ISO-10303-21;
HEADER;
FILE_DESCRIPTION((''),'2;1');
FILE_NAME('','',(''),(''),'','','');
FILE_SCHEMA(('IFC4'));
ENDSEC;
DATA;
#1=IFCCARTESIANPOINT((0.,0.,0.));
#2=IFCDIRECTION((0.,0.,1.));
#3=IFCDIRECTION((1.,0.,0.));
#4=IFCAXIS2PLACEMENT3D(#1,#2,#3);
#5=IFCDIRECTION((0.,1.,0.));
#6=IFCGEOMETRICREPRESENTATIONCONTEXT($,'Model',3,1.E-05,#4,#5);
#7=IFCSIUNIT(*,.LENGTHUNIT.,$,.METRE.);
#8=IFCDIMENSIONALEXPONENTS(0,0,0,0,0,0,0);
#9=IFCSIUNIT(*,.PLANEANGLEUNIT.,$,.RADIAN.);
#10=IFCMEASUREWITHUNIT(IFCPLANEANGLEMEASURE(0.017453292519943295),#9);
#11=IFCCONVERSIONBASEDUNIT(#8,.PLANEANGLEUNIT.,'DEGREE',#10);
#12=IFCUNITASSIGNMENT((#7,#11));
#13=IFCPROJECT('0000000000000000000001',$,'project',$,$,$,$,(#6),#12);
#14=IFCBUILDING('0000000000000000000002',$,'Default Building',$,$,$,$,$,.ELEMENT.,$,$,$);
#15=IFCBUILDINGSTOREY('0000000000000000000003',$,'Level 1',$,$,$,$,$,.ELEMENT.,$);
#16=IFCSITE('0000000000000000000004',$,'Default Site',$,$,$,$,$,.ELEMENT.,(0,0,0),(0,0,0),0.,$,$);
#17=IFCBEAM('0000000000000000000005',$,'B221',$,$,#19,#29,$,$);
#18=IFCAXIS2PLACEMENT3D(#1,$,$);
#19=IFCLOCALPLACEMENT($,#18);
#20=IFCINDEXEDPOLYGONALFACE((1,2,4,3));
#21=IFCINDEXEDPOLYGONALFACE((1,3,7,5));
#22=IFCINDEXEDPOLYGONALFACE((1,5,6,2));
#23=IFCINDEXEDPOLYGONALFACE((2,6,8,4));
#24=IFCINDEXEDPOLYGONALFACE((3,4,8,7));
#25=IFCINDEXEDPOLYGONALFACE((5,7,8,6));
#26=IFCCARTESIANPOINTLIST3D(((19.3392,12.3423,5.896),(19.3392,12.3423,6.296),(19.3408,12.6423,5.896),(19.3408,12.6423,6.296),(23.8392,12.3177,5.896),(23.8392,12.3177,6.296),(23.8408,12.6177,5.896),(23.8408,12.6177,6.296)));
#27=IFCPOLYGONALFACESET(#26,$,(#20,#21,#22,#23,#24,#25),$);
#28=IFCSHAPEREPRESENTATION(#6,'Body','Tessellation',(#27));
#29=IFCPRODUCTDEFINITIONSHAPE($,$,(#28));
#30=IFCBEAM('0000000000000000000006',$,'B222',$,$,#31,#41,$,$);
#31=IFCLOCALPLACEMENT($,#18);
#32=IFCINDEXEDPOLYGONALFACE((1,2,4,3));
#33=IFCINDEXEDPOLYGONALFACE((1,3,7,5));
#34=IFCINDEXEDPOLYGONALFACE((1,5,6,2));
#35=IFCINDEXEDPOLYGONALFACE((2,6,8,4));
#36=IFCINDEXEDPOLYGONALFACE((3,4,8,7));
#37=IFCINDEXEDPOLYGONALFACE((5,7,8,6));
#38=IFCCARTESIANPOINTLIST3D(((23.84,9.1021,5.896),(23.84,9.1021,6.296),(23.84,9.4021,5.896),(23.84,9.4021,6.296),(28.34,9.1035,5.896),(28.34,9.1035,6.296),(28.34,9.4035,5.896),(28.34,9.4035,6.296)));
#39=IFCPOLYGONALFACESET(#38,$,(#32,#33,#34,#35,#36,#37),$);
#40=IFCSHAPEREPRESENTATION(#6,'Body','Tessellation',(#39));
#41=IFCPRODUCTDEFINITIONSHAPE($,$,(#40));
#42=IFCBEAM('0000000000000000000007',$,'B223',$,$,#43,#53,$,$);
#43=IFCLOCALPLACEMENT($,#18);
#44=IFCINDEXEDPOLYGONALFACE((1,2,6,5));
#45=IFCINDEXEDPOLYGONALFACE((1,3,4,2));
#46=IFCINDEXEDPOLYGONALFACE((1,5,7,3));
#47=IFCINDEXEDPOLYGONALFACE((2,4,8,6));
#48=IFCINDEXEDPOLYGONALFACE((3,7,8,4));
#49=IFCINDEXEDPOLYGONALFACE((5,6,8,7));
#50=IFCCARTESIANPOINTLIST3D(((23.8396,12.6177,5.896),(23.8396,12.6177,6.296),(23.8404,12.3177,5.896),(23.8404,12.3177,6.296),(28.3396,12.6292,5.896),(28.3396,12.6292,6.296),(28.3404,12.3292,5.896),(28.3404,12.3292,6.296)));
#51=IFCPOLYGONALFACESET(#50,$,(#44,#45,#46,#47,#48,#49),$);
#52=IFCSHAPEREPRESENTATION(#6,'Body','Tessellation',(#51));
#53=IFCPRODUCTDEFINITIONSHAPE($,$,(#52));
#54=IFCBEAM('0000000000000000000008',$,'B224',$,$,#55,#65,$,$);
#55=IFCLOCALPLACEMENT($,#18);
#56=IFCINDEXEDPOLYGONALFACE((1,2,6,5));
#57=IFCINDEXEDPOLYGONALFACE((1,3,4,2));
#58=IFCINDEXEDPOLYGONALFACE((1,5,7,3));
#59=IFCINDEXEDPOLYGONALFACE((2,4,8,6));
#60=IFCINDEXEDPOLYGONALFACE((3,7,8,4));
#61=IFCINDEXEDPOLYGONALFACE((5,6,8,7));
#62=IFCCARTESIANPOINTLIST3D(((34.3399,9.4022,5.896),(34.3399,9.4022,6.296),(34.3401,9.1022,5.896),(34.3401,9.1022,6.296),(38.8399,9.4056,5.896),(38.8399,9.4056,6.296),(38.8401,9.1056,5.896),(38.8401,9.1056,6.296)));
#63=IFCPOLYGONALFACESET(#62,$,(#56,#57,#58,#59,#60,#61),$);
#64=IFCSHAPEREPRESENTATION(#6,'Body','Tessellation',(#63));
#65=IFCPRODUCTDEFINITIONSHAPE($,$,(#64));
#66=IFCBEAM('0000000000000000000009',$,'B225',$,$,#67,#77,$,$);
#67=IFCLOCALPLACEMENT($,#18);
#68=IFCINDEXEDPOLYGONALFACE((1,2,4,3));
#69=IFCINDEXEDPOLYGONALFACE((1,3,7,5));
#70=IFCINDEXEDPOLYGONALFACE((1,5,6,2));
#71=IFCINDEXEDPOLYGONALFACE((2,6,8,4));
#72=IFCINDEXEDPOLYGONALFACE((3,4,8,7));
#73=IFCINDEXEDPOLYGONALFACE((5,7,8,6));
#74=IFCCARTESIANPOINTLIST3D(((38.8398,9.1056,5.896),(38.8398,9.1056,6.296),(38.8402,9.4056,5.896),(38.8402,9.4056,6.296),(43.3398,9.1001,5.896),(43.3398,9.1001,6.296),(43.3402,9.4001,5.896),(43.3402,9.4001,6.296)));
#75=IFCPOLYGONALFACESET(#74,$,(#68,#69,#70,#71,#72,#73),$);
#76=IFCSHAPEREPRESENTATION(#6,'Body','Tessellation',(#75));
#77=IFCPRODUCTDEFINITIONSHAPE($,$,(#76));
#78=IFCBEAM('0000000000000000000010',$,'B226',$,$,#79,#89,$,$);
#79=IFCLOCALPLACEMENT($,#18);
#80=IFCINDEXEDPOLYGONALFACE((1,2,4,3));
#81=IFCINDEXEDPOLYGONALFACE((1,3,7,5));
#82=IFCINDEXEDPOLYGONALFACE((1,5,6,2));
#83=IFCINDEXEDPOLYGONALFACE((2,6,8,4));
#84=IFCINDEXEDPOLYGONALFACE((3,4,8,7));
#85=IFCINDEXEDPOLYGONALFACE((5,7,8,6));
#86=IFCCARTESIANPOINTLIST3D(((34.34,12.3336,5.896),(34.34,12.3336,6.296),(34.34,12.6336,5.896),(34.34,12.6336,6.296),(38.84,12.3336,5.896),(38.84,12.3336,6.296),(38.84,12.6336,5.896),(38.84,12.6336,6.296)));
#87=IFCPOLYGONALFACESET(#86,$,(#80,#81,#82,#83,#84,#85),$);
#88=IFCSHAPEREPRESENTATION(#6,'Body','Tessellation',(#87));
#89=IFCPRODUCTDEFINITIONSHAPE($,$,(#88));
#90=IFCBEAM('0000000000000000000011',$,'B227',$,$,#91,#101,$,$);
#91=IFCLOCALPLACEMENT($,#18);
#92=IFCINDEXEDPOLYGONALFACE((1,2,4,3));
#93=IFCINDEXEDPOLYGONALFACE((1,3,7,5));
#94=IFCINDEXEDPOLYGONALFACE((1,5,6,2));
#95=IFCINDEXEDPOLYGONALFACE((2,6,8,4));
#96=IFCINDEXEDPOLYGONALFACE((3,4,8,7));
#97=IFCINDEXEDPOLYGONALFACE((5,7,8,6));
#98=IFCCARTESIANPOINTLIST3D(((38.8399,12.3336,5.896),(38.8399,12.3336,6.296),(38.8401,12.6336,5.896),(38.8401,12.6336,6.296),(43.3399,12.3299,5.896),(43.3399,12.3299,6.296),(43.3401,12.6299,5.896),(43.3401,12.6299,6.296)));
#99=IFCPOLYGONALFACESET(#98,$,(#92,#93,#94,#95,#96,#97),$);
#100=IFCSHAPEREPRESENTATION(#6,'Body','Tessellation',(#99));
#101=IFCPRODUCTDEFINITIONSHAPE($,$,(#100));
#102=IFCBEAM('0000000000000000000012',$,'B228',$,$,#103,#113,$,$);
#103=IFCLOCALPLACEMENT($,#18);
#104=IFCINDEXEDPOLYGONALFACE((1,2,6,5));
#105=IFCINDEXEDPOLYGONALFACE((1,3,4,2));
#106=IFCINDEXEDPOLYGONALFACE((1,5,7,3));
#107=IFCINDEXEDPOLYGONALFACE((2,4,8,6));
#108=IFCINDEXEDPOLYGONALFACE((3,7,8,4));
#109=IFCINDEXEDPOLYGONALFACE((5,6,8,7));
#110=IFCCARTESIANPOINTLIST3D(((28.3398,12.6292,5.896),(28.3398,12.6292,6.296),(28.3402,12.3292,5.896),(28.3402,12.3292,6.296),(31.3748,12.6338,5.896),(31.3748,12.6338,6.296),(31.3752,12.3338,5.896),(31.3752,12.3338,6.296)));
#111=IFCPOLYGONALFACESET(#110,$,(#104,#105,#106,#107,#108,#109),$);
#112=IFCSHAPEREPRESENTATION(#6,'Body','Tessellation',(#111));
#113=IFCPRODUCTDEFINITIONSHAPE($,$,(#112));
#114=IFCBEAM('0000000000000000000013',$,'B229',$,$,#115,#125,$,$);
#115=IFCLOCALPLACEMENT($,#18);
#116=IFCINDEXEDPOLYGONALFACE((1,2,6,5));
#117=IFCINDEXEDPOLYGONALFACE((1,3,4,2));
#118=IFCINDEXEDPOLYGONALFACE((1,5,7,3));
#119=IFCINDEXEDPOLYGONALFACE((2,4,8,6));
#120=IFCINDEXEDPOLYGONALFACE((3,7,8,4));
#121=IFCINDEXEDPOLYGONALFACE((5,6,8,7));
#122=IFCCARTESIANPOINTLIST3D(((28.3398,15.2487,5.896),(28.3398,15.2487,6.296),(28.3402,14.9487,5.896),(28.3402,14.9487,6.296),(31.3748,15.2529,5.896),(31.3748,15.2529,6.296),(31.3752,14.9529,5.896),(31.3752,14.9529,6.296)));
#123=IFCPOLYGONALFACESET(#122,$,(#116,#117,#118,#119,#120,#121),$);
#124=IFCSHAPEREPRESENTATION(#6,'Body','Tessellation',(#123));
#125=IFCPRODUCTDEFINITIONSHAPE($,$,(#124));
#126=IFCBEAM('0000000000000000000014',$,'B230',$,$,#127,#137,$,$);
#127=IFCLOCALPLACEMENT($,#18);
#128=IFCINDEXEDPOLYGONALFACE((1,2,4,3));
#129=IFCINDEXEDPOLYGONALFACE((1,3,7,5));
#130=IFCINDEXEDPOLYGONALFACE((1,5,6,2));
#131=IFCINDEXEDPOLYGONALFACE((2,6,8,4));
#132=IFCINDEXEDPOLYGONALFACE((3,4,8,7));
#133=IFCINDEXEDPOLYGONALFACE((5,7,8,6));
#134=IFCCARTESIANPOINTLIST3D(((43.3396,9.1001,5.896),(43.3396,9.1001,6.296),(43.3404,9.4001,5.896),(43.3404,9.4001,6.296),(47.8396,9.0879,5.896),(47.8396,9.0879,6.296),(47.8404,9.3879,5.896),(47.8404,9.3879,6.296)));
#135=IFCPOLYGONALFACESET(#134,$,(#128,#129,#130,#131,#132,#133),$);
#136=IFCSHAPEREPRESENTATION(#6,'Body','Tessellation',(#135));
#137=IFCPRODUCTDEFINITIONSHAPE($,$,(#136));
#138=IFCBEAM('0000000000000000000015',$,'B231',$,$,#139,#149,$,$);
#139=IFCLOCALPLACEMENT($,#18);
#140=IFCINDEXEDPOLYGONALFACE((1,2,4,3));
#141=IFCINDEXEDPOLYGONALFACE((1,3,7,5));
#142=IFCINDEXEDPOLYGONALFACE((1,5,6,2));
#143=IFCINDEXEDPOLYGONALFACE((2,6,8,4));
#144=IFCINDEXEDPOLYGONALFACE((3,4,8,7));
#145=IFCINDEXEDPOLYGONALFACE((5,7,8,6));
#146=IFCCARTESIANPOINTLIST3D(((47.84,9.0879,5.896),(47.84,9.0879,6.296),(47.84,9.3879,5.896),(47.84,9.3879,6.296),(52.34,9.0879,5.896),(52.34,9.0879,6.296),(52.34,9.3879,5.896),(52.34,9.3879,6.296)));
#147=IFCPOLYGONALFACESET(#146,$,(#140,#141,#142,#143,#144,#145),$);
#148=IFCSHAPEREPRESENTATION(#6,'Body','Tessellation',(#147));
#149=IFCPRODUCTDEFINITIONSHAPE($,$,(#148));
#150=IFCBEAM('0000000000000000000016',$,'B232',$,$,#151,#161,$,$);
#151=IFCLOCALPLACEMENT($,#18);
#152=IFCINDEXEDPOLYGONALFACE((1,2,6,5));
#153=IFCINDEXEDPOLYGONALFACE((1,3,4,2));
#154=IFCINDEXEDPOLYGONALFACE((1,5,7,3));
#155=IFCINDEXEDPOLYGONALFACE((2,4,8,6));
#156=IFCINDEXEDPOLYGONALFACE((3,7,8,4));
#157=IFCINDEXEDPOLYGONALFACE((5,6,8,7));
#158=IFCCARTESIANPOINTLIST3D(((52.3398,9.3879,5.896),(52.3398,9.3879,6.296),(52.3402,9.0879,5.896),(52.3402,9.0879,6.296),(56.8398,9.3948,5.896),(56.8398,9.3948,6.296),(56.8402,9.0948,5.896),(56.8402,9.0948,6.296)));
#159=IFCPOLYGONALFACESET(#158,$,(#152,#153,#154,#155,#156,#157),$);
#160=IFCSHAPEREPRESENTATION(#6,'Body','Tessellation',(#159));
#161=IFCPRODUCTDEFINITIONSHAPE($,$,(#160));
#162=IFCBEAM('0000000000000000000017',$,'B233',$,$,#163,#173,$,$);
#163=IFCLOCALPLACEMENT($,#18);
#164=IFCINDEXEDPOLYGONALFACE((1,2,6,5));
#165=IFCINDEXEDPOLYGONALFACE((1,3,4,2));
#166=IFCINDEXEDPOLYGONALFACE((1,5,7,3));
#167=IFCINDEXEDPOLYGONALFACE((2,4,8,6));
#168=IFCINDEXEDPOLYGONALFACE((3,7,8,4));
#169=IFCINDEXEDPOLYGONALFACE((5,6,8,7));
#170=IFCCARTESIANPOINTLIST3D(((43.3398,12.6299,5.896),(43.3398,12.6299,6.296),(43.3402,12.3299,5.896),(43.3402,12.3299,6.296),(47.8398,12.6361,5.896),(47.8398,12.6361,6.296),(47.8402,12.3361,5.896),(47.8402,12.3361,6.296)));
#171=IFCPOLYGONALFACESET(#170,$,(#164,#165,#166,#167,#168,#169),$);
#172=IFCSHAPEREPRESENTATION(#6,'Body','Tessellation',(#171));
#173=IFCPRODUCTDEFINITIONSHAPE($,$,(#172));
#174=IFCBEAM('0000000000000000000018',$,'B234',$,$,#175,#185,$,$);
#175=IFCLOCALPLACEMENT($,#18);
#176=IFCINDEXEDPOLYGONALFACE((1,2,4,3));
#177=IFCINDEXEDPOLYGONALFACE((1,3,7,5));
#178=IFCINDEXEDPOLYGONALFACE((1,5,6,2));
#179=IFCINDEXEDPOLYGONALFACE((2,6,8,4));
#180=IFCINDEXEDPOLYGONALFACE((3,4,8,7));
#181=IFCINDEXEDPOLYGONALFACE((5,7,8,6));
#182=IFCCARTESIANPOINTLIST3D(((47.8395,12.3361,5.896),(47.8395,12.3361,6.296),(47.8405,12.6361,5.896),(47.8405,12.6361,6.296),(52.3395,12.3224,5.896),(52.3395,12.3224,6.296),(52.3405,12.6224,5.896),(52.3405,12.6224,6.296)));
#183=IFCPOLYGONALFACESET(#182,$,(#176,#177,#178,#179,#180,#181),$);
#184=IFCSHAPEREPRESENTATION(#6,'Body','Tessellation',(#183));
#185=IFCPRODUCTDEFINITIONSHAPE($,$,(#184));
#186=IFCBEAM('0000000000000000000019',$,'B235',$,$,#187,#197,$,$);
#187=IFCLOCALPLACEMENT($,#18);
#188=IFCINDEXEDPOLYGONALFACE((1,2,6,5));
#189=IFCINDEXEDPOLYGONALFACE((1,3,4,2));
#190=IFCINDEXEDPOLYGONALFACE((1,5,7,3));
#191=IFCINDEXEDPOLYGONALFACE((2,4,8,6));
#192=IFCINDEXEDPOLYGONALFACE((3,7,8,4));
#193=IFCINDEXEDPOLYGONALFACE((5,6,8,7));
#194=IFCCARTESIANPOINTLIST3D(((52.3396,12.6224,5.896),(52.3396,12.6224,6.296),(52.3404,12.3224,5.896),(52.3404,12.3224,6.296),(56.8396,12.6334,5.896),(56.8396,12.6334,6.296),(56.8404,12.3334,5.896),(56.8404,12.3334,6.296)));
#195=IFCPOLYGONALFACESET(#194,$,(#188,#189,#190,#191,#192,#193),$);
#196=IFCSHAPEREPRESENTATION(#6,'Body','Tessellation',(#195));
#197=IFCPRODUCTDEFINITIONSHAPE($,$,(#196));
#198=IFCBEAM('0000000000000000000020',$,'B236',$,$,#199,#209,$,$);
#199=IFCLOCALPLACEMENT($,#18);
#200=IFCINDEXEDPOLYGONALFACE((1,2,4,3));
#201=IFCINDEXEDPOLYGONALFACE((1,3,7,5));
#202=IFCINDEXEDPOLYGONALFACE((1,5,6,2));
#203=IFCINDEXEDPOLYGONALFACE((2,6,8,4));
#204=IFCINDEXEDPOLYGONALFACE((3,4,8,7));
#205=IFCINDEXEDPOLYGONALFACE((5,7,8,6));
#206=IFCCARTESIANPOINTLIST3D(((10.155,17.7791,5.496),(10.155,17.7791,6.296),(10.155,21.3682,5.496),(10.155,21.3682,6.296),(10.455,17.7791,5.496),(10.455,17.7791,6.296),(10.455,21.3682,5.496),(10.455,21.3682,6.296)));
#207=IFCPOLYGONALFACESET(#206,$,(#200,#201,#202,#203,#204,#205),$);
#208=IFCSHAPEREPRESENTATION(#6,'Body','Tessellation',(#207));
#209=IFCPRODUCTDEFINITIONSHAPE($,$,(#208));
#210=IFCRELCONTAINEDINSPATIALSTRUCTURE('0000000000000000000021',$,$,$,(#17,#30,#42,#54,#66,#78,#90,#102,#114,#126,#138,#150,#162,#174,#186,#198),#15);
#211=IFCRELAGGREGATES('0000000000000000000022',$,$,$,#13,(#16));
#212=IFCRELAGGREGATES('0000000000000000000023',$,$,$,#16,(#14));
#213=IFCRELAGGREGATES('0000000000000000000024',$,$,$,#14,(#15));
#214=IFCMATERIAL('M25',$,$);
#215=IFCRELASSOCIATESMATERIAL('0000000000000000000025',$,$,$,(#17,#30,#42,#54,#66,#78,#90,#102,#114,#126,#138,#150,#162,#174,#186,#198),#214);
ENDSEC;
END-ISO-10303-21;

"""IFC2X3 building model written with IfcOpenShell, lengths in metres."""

from ifc_helpers import new_model, entity, si_unit, converted_unit, direction, frame, frame_2d, origin_with_axes, place, context, project, spatial, rectangle, extrude, material, element, save


model = new_model("IFC2X3")

# Units and contexts
model_context = context("Model", 3, precision=1e-05, world=origin_with_axes(), true_north=direction((0.0, 1.0, 0.0)))
ifc_project = project(units=[si_unit("LENGTHUNIT", "METRE"), converted_unit("PLANEANGLEUNIT", "DEGREE", entity("IfcPlaneAngleMeasure", 0.017453292519943295), si_unit("PLANEANGLEUNIT", "RADIAN"), dimensions=[0, 0, 0, 0, 0, 0, 0])], contexts=[model_context])

# Site, building, storey
site = spatial("IfcSite", under=ifc_project, Name="Default Site", CompositionType="ELEMENT", RefLatitude=(0, 0, 0), RefLongitude=(0, 0, 0), RefElevation=0.0)
building = spatial("IfcBuilding", under=site, Name="Default Building", CompositionType="ELEMENT")
storey = spatial("IfcBuildingStorey", under=building, Name="Level 1", CompositionType="ELEMENT")

# Beams
ifc_material = material(Name="M25")
placement = place(None, origin_with_axes())
element("IfcBeam", 1, at=placement, inside=storey, material=ifc_material, Name="B221", context=model_context, shape_type="SweptSolid", body=[
    extrude(rectangle(XDim=0.3, YDim=0.4, at=frame_2d((0.0, 0.0), x_axis=(0.0, 1.0, 0.0))), frame((19.34, 12.4923, 6.096), z_axis=(0.999985, -0.005463, 0.0), x_axis=(0.0, 0.0, -1.0)), (0.0, 0.0, 1.0), 4.5001),
])
element("IfcBeam", 2, at=placement, inside=storey, material=ifc_material, Name="B222", context=model_context, shape_type="SweptSolid", body=[
    extrude(rectangle(XDim=0.3, YDim=0.4, at=frame_2d((0.0, 0.0), x_axis=(0.0, 1.0, 0.0))), frame((23.84, 9.2521, 6.096), z_axis=(1.0, 0.000307, 0.0), x_axis=(0.0, 0.0, -1.0)), (0.0, 0.0, 1.0), 4.5),
])
element("IfcBeam", 3, at=placement, inside=storey, material=ifc_material, Name="B223", context=model_context, shape_type="SweptSolid", body=[
    extrude(rectangle(XDim=0.3, YDim=0.4, at=frame_2d((0.0, 0.0), x_axis=(0.0, 1.0, 0.0))), frame((23.84, 12.4677, 6.096), z_axis=(0.999997, 0.002551, 0.0), x_axis=(0.0, 0.0, -1.0)), (0.0, 0.0, 1.0), 4.5),
])
element("IfcBeam", 4, at=placement, inside=storey, material=ifc_material, Name="B224", context=model_context, shape_type="SweptSolid", body=[
    extrude(rectangle(XDim=0.3, YDim=0.4, at=frame_2d((0.0, 0.0), x_axis=(0.0, 1.0, 0.0))), frame((34.34, 9.2522, 6.096), z_axis=(1.0, 0.000748, 0.0), x_axis=(0.0, 0.0, -1.0)), (0.0, 0.0, 1.0), 4.5),
])
element("IfcBeam", 5, at=placement, inside=storey, material=ifc_material, Name="B225", context=model_context, shape_type="SweptSolid", body=[
    extrude(rectangle(XDim=0.3, YDim=0.4, at=frame_2d((0.0, 0.0), x_axis=(0.0, 1.0, 0.0))), frame((38.84, 9.2556, 6.096), z_axis=(0.999999, -0.001227, 0.0), x_axis=(0.0, 0.0, -1.0)), (0.0, 0.0, 1.0), 4.5),
])
element("IfcBeam", 6, at=placement, inside=storey, material=ifc_material, Name="B226", context=model_context, shape_type="SweptSolid", body=[
    extrude(rectangle(XDim=0.3, YDim=0.4, at=frame_2d((0.0, 0.0), x_axis=(0.0, 1.0, 0.0))), frame((34.34, 12.4836, 6.096), z_axis=(1.0, -0.000008, 0.0), x_axis=(0.0, 0.0, -1.0)), (0.0, 0.0, 1.0), 4.5),
])
element("IfcBeam", 7, at=placement, inside=storey, material=ifc_material, Name="B227", context=model_context, shape_type="SweptSolid", body=[
    extrude(rectangle(XDim=0.3, YDim=0.4, at=frame_2d((0.0, 0.0), x_axis=(0.0, 1.0, 0.0))), frame((38.84, 12.4836, 6.096), z_axis=(1.0, -0.000826, 0.0), x_axis=(0.0, 0.0, -1.0)), (0.0, 0.0, 1.0), 4.5),
])
element("IfcBeam", 8, at=placement, inside=storey, material=ifc_material, Name="B228", context=model_context, shape_type="SweptSolid", body=[
    extrude(rectangle(XDim=0.3, YDim=0.4, at=frame_2d((0.0, 0.0), x_axis=(0.0, 1.0, 0.0))), frame((28.34, 12.4792, 6.096), z_axis=(0.999999, 0.001542, 0.0), x_axis=(0.0, 0.0, -1.0)), (0.0, 0.0, 1.0), 3.035),
])
element("IfcBeam", 9, at=placement, inside=storey, material=ifc_material, Name="B229", context=model_context, shape_type="SweptSolid", body=[
    extrude(rectangle(XDim=0.3, YDim=0.4, at=frame_2d((0.0, 0.0), x_axis=(0.0, 1.0, 0.0))), frame((31.375, 15.1029, 6.096), z_axis=(-0.999999, -0.001391, 0.0), x_axis=(0.0, 0.0, -1.0)), (0.0, 0.0, 1.0), 3.035),
])
element("IfcBeam", 10, at=placement, inside=storey, material=ifc_material, Name="B230", context=model_context, shape_type="SweptSolid", body=[
    extrude(rectangle(XDim=0.3, YDim=0.4, at=frame_2d((0.0, 0.0), x_axis=(0.0, 1.0, 0.0))), frame((43.34, 9.2501, 6.096), z_axis=(0.999996, -0.002702, 0.0), x_axis=(0.0, 0.0, -1.0)), (0.0, 0.0, 1.0), 4.5),
])
element("IfcBeam", 11, at=placement, inside=storey, material=ifc_material, Name="B231", context=model_context, shape_type="SweptSolid", body=[
    extrude(rectangle(XDim=0.3, YDim=0.4, at=frame_2d((0.0, 0.0), x_axis=(0.0, 1.0, 0.0))), frame((47.84, 9.2379, 6.096), z_axis=(1.0, 0.0, 0.0), x_axis=(0.0, 0.0, -1.0)), (0.0, 0.0, 1.0), 4.5),
])
element("IfcBeam", 12, at=placement, inside=storey, material=ifc_material, Name="B232", context=model_context, shape_type="SweptSolid", body=[
    extrude(rectangle(XDim=0.3, YDim=0.4, at=frame_2d((0.0, 0.0), x_axis=(0.0, 1.0, 0.0))), frame((52.34, 9.2379, 6.096), z_axis=(0.999999, 0.001537, 0.0), x_axis=(0.0, 0.0, -1.0)), (0.0, 0.0, 1.0), 4.5),
])
element("IfcBeam", 13, at=placement, inside=storey, material=ifc_material, Name="B233", context=model_context, shape_type="SweptSolid", body=[
    extrude(rectangle(XDim=0.3, YDim=0.4, at=frame_2d((0.0, 0.0), x_axis=(0.0, 1.0, 0.0))), frame((43.34, 12.4799, 6.096), z_axis=(0.999999, 0.001374, 0.0), x_axis=(0.0, 0.0, -1.0)), (0.0, 0.0, 1.0), 4.5),
])
element("IfcBeam", 14, at=placement, inside=storey, material=ifc_material, Name="B234", context=model_context, shape_type="SweptSolid", body=[
    extrude(rectangle(XDim=0.3, YDim=0.4, at=frame_2d((0.0, 0.0), x_axis=(0.0, 1.0, 0.0))), frame((47.84, 12.4861, 6.096), z_axis=(0.999995, -0.003045, 0.0), x_axis=(0.0, 0.0, -1.0)), (0.0, 0.0, 1.0), 4.5),
])
element("IfcBeam", 15, at=placement, inside=storey, material=ifc_material, Name="B235", context=model_context, shape_type="SweptSolid", body=[
    extrude(rectangle(XDim=0.3, YDim=0.4, at=frame_2d((0.0, 0.0), x_axis=(0.0, 1.0, 0.0))), frame((52.34, 12.4724, 6.096), z_axis=(0.999997, 0.002456, 0.0), x_axis=(0.0, 0.0, -1.0)), (0.0, 0.0, 1.0), 4.5),
])
element("IfcBeam", 16, at=placement, inside=storey, material=ifc_material, Name="B236", context=model_context, shape_type="SweptSolid", body=[
    extrude(rectangle(XDim=0.3, YDim=0.8, at=frame_2d((0.0, 0.0), x_axis=(0.0, 1.0, 0.0))), frame((10.305, 21.3682, 5.896), z_axis=(0.0, -1.0, 0.0), x_axis=(0.0, 0.0, -1.0)), (0.0, 0.0, 1.0), 3.5891),
])

save(model, "model.ifc")
